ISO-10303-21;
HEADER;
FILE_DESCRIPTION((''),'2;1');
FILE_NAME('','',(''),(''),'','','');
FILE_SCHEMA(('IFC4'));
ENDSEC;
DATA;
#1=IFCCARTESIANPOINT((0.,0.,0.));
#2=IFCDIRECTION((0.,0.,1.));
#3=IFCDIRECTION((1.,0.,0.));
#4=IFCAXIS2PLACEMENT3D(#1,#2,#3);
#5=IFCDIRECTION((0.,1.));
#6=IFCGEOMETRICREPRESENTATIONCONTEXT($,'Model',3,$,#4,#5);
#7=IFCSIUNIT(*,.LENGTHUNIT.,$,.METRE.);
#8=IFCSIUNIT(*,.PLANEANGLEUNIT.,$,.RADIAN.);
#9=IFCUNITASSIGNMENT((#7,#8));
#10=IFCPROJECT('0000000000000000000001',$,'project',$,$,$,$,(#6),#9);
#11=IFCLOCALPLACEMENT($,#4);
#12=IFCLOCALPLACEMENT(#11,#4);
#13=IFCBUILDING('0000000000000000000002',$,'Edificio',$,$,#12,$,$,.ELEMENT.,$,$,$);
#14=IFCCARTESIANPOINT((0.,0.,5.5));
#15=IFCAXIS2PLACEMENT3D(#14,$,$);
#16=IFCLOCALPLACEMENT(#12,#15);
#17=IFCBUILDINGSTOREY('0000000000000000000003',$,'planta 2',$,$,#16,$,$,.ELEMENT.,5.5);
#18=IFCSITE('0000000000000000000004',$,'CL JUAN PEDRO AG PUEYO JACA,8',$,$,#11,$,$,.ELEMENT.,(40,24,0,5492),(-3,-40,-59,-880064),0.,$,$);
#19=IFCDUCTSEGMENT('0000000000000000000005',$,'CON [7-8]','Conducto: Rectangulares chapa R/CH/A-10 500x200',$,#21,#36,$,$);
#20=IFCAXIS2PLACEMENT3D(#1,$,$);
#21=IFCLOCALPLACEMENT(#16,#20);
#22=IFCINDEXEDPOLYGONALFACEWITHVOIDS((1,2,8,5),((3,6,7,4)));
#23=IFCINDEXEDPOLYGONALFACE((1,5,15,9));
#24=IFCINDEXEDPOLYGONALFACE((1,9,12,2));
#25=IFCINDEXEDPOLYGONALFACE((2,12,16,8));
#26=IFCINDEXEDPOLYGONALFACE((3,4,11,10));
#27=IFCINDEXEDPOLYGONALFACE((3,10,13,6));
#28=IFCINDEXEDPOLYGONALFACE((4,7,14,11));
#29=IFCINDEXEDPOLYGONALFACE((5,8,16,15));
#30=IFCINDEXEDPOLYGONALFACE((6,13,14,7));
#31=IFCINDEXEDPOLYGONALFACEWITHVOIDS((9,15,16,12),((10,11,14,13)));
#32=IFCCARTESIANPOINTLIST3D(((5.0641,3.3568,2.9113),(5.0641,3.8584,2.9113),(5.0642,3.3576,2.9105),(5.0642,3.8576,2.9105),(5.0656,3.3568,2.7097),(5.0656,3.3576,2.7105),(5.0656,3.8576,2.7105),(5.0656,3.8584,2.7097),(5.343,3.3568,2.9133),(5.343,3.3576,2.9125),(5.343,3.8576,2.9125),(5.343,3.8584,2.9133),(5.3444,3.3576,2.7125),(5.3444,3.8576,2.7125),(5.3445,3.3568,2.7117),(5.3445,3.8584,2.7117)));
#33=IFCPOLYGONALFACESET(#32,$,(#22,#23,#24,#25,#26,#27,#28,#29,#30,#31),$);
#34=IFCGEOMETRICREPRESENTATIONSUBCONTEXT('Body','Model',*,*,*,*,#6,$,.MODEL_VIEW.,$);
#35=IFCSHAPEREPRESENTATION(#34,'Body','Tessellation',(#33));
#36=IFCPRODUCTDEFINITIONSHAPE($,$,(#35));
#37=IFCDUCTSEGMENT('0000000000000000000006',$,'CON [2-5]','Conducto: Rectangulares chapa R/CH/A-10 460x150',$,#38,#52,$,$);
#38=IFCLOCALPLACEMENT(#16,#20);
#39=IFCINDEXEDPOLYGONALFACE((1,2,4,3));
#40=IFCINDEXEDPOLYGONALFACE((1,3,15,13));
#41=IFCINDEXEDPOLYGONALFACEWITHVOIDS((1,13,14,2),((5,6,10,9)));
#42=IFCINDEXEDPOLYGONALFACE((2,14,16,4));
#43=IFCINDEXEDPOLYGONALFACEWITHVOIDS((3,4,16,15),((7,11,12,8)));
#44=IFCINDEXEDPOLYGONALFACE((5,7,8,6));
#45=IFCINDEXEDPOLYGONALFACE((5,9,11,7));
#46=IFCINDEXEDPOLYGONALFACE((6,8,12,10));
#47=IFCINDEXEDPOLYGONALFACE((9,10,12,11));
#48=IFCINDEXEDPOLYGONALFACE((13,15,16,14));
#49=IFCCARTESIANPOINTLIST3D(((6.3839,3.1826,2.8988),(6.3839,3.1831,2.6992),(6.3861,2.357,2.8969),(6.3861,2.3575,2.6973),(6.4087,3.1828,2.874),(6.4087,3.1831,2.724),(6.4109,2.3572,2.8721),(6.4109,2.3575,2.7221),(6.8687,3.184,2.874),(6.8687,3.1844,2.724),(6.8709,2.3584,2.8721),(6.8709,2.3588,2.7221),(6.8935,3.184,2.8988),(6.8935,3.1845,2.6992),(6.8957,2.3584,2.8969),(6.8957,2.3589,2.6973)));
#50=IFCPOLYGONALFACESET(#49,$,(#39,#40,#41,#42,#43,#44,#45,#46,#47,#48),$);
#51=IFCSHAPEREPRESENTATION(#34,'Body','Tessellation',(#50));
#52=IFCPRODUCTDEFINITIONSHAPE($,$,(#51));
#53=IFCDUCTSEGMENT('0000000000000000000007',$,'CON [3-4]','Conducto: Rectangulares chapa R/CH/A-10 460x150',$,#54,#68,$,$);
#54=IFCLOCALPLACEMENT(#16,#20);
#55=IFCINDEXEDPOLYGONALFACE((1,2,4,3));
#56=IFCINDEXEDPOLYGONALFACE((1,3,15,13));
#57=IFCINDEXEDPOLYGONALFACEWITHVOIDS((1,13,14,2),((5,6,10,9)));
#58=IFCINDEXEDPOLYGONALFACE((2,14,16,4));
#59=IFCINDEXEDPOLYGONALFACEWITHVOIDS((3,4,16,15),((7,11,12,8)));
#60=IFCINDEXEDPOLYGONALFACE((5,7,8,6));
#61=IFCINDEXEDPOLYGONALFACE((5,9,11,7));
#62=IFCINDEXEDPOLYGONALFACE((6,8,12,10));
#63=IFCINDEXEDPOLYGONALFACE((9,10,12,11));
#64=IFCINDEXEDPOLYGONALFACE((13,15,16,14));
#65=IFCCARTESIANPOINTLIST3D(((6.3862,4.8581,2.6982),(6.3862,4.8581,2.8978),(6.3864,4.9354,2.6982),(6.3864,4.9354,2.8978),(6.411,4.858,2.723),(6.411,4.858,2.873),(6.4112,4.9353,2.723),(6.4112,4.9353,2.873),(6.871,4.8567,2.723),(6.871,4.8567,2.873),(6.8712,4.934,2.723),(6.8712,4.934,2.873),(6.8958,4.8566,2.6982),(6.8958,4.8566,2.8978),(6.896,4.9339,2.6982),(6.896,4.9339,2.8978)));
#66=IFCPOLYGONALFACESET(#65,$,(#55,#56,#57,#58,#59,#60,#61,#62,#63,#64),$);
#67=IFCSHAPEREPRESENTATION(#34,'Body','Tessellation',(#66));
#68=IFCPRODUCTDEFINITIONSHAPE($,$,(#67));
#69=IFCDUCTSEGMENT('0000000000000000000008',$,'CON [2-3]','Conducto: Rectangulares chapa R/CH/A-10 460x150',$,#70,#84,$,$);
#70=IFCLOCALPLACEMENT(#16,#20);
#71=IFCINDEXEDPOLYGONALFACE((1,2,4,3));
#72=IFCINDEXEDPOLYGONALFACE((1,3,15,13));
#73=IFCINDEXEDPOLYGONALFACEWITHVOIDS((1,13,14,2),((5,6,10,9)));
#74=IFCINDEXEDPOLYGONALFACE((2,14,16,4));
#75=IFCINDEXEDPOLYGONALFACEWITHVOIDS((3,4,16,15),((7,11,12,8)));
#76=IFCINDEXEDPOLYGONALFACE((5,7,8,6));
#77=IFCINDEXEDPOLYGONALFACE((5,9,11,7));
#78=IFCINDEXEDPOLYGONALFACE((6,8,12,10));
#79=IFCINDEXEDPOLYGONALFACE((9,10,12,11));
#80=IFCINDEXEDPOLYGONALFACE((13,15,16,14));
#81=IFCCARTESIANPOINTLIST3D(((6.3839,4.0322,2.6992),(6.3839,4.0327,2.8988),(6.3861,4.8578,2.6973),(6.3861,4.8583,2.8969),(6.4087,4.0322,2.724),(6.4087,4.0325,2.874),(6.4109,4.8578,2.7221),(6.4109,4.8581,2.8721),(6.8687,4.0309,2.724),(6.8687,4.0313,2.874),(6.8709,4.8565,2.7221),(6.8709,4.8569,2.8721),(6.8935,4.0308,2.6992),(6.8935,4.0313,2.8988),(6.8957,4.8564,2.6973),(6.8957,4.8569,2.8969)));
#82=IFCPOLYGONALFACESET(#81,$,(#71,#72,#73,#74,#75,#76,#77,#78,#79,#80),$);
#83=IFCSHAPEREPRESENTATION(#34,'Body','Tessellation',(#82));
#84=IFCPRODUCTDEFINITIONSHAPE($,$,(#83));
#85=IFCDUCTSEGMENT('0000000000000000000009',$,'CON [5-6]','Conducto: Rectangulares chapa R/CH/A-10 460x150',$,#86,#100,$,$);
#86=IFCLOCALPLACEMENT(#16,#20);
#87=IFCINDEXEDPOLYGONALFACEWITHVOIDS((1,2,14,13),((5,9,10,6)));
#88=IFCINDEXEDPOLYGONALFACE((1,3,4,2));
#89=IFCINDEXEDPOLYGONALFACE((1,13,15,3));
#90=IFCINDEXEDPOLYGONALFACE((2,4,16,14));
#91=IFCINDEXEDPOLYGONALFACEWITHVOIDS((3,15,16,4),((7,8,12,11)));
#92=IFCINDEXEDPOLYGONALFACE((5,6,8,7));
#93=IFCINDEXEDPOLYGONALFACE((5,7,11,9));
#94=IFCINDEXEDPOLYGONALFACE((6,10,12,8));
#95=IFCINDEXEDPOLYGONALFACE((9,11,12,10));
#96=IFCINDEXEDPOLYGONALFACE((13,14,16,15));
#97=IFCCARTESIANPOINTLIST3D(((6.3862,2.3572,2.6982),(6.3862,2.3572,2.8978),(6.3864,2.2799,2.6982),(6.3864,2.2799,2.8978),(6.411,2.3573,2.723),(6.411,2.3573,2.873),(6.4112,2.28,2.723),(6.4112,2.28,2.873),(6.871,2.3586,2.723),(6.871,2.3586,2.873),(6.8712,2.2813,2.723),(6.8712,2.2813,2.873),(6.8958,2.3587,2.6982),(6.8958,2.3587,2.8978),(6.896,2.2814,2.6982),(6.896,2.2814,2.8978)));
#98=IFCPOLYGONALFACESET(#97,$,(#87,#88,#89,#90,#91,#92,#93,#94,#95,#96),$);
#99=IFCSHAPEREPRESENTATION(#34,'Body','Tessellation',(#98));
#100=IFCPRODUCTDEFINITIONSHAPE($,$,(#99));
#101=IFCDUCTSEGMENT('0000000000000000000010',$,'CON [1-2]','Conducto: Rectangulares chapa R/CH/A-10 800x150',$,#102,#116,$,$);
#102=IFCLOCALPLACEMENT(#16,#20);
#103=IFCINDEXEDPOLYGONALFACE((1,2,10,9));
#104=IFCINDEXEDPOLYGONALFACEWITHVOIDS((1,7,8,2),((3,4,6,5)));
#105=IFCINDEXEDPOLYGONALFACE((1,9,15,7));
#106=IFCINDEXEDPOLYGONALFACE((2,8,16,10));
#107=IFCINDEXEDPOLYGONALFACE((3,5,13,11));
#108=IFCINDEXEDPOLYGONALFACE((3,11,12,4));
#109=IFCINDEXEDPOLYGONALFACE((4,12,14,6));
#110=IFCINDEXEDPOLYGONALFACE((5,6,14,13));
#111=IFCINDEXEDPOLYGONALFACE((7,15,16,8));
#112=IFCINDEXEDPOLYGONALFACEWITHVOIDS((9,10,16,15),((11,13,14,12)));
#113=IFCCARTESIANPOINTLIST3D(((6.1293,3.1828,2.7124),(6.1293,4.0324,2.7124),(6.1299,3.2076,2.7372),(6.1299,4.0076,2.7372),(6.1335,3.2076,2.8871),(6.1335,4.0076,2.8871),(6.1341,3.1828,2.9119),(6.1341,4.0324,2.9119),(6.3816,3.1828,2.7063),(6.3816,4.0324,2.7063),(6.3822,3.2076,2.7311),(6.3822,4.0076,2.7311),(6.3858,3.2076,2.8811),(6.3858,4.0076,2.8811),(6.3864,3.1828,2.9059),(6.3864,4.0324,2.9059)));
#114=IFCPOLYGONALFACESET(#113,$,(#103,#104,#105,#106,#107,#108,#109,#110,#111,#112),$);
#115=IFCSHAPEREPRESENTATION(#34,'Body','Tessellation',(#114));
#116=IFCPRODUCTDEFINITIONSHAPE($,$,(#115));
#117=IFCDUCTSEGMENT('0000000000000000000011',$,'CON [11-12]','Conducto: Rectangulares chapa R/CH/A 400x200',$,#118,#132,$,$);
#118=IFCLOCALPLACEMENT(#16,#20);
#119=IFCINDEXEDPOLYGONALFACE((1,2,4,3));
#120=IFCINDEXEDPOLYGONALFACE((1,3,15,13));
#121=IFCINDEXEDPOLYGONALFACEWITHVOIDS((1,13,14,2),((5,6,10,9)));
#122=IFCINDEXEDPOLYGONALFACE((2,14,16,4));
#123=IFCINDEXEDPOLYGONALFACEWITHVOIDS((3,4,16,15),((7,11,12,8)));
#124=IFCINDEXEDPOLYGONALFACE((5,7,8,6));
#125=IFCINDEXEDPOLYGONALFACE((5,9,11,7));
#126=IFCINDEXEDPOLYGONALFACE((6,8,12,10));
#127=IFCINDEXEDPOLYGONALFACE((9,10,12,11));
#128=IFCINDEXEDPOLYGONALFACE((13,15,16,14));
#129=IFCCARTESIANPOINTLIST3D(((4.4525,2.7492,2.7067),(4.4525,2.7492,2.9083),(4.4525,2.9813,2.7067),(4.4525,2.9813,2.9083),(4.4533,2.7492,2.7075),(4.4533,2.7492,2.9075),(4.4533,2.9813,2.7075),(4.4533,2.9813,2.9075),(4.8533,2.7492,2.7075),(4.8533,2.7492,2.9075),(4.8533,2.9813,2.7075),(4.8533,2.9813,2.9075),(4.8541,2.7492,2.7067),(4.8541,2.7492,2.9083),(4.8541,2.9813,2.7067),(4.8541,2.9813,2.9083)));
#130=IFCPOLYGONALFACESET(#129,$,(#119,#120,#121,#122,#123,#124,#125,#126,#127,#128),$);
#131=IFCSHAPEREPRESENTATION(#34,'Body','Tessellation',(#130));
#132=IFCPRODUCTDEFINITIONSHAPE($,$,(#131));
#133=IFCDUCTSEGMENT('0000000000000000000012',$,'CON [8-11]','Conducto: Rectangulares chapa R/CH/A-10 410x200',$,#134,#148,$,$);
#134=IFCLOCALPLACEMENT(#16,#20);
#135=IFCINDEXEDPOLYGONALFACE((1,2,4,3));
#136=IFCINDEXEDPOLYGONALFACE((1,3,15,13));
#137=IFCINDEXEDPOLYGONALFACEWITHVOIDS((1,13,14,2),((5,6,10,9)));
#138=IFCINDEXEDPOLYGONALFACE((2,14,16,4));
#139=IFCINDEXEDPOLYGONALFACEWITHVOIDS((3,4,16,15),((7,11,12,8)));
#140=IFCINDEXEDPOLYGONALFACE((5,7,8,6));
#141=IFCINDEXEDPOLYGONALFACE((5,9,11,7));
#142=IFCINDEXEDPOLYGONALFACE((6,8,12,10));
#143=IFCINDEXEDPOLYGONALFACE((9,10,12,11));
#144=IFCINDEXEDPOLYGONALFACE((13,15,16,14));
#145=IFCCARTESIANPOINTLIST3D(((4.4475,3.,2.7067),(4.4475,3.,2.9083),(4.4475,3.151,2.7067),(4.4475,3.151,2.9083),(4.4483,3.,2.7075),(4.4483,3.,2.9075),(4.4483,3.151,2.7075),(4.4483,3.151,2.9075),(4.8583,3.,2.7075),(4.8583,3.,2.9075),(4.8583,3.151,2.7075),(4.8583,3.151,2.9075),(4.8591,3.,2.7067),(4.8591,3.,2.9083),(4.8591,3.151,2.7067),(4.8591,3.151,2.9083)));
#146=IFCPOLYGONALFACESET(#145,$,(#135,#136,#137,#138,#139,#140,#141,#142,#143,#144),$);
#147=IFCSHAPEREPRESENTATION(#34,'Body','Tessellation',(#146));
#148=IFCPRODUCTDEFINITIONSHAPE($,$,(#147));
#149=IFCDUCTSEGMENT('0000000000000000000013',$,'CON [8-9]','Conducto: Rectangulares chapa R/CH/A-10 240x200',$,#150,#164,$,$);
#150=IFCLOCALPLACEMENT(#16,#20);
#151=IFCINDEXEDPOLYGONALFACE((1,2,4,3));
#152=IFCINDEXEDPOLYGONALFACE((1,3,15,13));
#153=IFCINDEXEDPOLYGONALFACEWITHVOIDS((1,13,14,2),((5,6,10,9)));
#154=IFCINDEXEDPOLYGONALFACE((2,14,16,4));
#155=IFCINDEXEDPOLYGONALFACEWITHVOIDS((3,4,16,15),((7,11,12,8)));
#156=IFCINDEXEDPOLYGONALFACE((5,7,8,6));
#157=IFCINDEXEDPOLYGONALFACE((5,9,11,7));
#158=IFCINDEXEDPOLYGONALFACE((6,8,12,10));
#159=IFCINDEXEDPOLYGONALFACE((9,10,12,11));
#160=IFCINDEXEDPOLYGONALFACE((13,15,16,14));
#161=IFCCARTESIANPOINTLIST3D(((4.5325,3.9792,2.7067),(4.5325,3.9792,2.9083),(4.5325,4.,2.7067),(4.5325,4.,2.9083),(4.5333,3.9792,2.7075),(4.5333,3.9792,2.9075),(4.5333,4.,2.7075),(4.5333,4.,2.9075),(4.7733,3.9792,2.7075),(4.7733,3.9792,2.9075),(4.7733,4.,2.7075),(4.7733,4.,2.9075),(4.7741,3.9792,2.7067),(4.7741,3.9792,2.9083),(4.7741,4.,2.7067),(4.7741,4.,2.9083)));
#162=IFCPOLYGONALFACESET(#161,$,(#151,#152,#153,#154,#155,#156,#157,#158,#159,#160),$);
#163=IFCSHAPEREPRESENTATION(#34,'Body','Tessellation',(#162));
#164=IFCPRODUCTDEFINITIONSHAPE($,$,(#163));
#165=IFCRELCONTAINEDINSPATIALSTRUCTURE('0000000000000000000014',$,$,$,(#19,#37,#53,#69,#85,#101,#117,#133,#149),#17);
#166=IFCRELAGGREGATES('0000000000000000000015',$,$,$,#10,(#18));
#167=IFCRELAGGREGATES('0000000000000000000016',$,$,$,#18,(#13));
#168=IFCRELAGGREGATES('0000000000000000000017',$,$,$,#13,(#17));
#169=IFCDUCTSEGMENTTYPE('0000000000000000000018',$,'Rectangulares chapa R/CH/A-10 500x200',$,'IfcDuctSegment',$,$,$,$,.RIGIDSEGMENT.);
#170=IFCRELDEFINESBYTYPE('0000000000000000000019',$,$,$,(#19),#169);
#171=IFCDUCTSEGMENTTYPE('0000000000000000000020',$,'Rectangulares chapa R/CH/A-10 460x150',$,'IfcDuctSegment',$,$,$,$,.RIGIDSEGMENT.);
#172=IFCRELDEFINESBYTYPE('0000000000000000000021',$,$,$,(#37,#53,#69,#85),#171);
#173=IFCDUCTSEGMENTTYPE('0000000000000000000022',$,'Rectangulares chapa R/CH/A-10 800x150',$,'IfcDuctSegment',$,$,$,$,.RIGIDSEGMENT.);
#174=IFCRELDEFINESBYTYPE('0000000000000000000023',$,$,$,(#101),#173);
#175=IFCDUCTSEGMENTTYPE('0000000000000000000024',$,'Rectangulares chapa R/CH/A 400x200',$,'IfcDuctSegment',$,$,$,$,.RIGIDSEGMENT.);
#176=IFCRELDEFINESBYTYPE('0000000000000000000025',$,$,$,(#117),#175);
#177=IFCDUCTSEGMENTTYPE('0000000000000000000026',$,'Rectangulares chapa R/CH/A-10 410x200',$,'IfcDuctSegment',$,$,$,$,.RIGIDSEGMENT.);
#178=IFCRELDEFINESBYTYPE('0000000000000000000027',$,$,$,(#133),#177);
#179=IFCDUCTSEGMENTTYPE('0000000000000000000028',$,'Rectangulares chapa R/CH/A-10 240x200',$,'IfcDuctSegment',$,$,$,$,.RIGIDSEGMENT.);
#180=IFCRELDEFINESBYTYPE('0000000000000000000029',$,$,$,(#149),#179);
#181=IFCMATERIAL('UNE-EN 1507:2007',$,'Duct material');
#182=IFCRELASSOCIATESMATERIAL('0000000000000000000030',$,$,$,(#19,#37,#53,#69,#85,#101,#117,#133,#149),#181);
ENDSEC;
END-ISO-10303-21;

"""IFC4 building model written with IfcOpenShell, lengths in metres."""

from ifc_helpers import new_model, si_unit, direction, frame, origin_with_axes, origin_2d_with_axis, place, context, subcontext, project, spatial, hollow_rectangle, extrude, material, type_object, element, save


model = new_model("IFC4")

# Units and contexts
model_context = context("Model", 3, world=origin_with_axes(), true_north=direction((0.0, 1.0)))
body_context = subcontext(model_context, "Body", "Model", "MODEL_VIEW")
ifc_project = project(units=[si_unit("LENGTHUNIT", "METRE"), si_unit("PLANEANGLEUNIT", "RADIAN")], contexts=[model_context])

# Site, building, storey
site_placement = place(None, origin_with_axes())
site = spatial("IfcSite", under=ifc_project, at=site_placement, Name="CL JUAN PEDRO AG PUEYO JACA,8", CompositionType="ELEMENT", RefLatitude=(40, 24, 0, 5492), RefLongitude=(-3, -40, -59, -880064), RefElevation=0.0)
building_placement = place(site_placement, origin_with_axes())
building = spatial("IfcBuilding", under=site, at=building_placement, Name="Edificio", CompositionType="ELEMENT")
storey_placement = place(building_placement, frame((0.0, 0.0, 5.5)))
storey = spatial("IfcBuildingStorey", under=building, at=storey_placement, Name="planta 2", CompositionType="ELEMENT", Elevation=5.5)

# Duct segments
ifc_material = material(Name="UNE-EN 1507:2007", Category="Duct material")
duct_segment_type_1 = type_object("IfcDuctSegmentType", Name="Rectangulares chapa R/CH/A-10 500x200", ApplicableOccurrence="IfcDuctSegment", PredefinedType="RIGIDSEGMENT")
duct_segment_1_placement = place(storey_placement, frame((0.0, 0.0, -5.5), z_axis=(0.0, 0.0, 1.0), x_axis=(1.0, 0.0, 0.0)))
element("IfcDuctSegment", 1, at=duct_segment_1_placement, inside=storey, type_object=duct_segment_type_1, material=ifc_material, Name="CON [7-8]", Description="Conducto: Rectangulares chapa R/CH/A-10 500x200", context=body_context, shape_type="SweptSolid", body=[
    extrude(hollow_rectangle(XDim=0.5016, YDim=0.2016, WallThickness=0.0008, at=origin_2d_with_axis()), frame((5.3437, 3.6076, 8.3125), z_axis=(-0.999974, 0.0, -0.00721), x_axis=(0.0, -1.0, 0.0)), (0.0, 0.0, 1.0), 0.2789),
])
duct_segment_type_2 = type_object("IfcDuctSegmentType", Name="Rectangulares chapa R/CH/A-10 460x150", ApplicableOccurrence="IfcDuctSegment", PredefinedType="RIGIDSEGMENT")
duct_segment_2_placement = place(storey_placement, frame((0.0, 0.0, -5.5), z_axis=(0.0, 0.0, 1.0), x_axis=(1.0, 0.0, 0.0)))
element("IfcDuctSegment", 2, at=duct_segment_2_placement, inside=storey, type_object=duct_segment_type_2, material=ifc_material, Name="CON [2-5]", Description="Conducto: Rectangulares chapa R/CH/A-10 460x150", context=body_context, shape_type="SweptSolid", body=[
    extrude(hollow_rectangle(XDim=0.5096, YDim=0.1996, WallThickness=0.0248, at=origin_2d_with_axis()), frame((6.6387, 3.1836, 8.299), z_axis=(0.002747, -0.999993, -0.002354), x_axis=(0.999996, 0.002747, 0.0)), (0.0, 0.0, 1.0), 0.8256),
])
duct_segment_3_placement = place(storey_placement, frame((0.0, 0.0, -5.5), z_axis=(0.0, 0.0, 1.0), x_axis=(1.0, 0.0, 0.0)))
element("IfcDuctSegment", 3, at=duct_segment_3_placement, inside=storey, type_object=duct_segment_type_2, material=ifc_material, Name="CON [3-4]", Description="Conducto: Rectangulares chapa R/CH/A-10 460x150", context=body_context, shape_type="SweptSolid", body=[
    extrude(hollow_rectangle(XDim=0.5096, YDim=0.1996, WallThickness=0.0248, at=origin_2d_with_axis()), frame((6.641, 4.8573, 8.298), z_axis=(0.002827, 0.999996, 0.0), x_axis=(-0.999996, 0.002827, 0.0)), (0.0, 0.0, 1.0), 0.0773),
])
duct_segment_4_placement = place(storey_placement, frame((0.0, 0.0, -5.5), z_axis=(0.0, 0.0, 1.0), x_axis=(1.0, 0.0, 0.0)))
element("IfcDuctSegment", 4, at=duct_segment_4_placement, inside=storey, type_object=duct_segment_type_2, material=ifc_material, Name="CON [2-3]", Description="Conducto: Rectangulares chapa R/CH/A-10 460x150", context=body_context, shape_type="SweptSolid", body=[
    extrude(hollow_rectangle(XDim=0.5096, YDim=0.1996, WallThickness=0.0248, at=origin_2d_with_axis()), frame((6.6387, 4.0317, 8.299), z_axis=(0.002747, 0.999993, -0.002354), x_axis=(-0.999996, 0.002747, 0.0)), (0.0, 0.0, 1.0), 0.8256),
])
duct_segment_5_placement = place(storey_placement, frame((0.0, 0.0, -5.5), z_axis=(0.0, 0.0, 1.0), x_axis=(1.0, 0.0, 0.0)))
element("IfcDuctSegment", 5, at=duct_segment_5_placement, inside=storey, type_object=duct_segment_type_2, material=ifc_material, Name="CON [5-6]", Description="Conducto: Rectangulares chapa R/CH/A-10 460x150", context=body_context, shape_type="SweptSolid", body=[
    extrude(hollow_rectangle(XDim=0.5096, YDim=0.1996, WallThickness=0.0248, at=origin_2d_with_axis()), frame((6.641, 2.358, 8.298), z_axis=(0.002827, -0.999996, 0.0), x_axis=(0.999996, 0.002827, 0.0)), (0.0, 0.0, 1.0), 0.0773),
])
duct_segment_type_3 = type_object("IfcDuctSegmentType", Name="Rectangulares chapa R/CH/A-10 800x150", ApplicableOccurrence="IfcDuctSegment", PredefinedType="RIGIDSEGMENT")
duct_segment_6_placement = place(storey_placement, frame((0.0, 0.0, -5.5), z_axis=(0.0, 0.0, 1.0), x_axis=(1.0, 0.0, 0.0)))
element("IfcDuctSegment", 6, at=duct_segment_6_placement, inside=storey, type_object=duct_segment_type_3, material=ifc_material, Name="CON [1-2]", Description="Conducto: Rectangulares chapa R/CH/A-10 800x150", context=body_context, shape_type="SweptSolid", body=[
    extrude(hollow_rectangle(XDim=0.8496, YDim=0.1996, WallThickness=0.0248, at=origin_2d_with_axis()), frame((6.1317, 3.6076, 8.3121), z_axis=(0.999712, 0.0, -0.023995), x_axis=(0.0, 1.0, 0.0)), (0.0, 0.0, 1.0), 0.2523),
])
duct_segment_type_4 = type_object("IfcDuctSegmentType", Name="Rectangulares chapa R/CH/A 400x200", ApplicableOccurrence="IfcDuctSegment", PredefinedType="RIGIDSEGMENT")
duct_segment_7_placement = place(storey_placement, frame((0.0, 0.0, -5.5), z_axis=(0.0, 0.0, 1.0), x_axis=(1.0, 0.0, 0.0)))
element("IfcDuctSegment", 7, at=duct_segment_7_placement, inside=storey, type_object=duct_segment_type_4, material=ifc_material, Name="CON [11-12]", Description="Conducto: Rectangulares chapa R/CH/A 400x200", context=body_context, shape_type="SweptSolid", body=[
    extrude(hollow_rectangle(XDim=0.4016, YDim=0.2016, WallThickness=0.0008, at=origin_2d_with_axis()), frame((4.6533, 2.9813, 8.3075), z_axis=(0.0, -1.0, 0.0), x_axis=(1.0, 0.0, 0.0)), (0.0, 0.0, 1.0), 0.2321),
])
duct_segment_type_5 = type_object("IfcDuctSegmentType", Name="Rectangulares chapa R/CH/A-10 410x200", ApplicableOccurrence="IfcDuctSegment", PredefinedType="RIGIDSEGMENT")
duct_segment_8_placement = place(storey_placement, frame((0.0, 0.0, -5.5), z_axis=(0.0, 0.0, 1.0), x_axis=(1.0, 0.0, 0.0)))
element("IfcDuctSegment", 8, at=duct_segment_8_placement, inside=storey, type_object=duct_segment_type_5, material=ifc_material, Name="CON [8-11]", Description="Conducto: Rectangulares chapa R/CH/A-10 410x200", context=body_context, shape_type="SweptSolid", body=[
    extrude(hollow_rectangle(XDim=0.4116, YDim=0.2016, WallThickness=0.0008, at=origin_2d_with_axis()), frame((4.6533, 3.151, 8.3075), z_axis=(0.0, -1.0, 0.0), x_axis=(1.0, 0.0, 0.0)), (0.0, 0.0, 1.0), 0.151),
])

# Duct segment
duct_segment_type_6 = type_object("IfcDuctSegmentType", Name="Rectangulares chapa R/CH/A-10 240x200", ApplicableOccurrence="IfcDuctSegment", PredefinedType="RIGIDSEGMENT")
duct_segment_9_placement = place(storey_placement, frame((0.0, 0.0, -5.5), z_axis=(0.0, 0.0, 1.0), x_axis=(1.0, 0.0, 0.0)))
element("IfcDuctSegment", 9, at=duct_segment_9_placement, inside=storey, type_object=duct_segment_type_6, material=ifc_material, Name="CON [8-9]", Description="Conducto: Rectangulares chapa R/CH/A-10 240x200", context=body_context, shape_type="SweptSolid", body=[
    extrude(hollow_rectangle(XDim=0.2416, YDim=0.2016, WallThickness=0.0008, at=origin_2d_with_axis()), frame((4.6533, 3.9792, 8.3075), z_axis=(0.0, 1.0, 0.0), x_axis=(-1.0, 0.0, 0.0)), (0.0, 0.0, 1.0), 0.0208),
])

save(model, "model.ifc")
